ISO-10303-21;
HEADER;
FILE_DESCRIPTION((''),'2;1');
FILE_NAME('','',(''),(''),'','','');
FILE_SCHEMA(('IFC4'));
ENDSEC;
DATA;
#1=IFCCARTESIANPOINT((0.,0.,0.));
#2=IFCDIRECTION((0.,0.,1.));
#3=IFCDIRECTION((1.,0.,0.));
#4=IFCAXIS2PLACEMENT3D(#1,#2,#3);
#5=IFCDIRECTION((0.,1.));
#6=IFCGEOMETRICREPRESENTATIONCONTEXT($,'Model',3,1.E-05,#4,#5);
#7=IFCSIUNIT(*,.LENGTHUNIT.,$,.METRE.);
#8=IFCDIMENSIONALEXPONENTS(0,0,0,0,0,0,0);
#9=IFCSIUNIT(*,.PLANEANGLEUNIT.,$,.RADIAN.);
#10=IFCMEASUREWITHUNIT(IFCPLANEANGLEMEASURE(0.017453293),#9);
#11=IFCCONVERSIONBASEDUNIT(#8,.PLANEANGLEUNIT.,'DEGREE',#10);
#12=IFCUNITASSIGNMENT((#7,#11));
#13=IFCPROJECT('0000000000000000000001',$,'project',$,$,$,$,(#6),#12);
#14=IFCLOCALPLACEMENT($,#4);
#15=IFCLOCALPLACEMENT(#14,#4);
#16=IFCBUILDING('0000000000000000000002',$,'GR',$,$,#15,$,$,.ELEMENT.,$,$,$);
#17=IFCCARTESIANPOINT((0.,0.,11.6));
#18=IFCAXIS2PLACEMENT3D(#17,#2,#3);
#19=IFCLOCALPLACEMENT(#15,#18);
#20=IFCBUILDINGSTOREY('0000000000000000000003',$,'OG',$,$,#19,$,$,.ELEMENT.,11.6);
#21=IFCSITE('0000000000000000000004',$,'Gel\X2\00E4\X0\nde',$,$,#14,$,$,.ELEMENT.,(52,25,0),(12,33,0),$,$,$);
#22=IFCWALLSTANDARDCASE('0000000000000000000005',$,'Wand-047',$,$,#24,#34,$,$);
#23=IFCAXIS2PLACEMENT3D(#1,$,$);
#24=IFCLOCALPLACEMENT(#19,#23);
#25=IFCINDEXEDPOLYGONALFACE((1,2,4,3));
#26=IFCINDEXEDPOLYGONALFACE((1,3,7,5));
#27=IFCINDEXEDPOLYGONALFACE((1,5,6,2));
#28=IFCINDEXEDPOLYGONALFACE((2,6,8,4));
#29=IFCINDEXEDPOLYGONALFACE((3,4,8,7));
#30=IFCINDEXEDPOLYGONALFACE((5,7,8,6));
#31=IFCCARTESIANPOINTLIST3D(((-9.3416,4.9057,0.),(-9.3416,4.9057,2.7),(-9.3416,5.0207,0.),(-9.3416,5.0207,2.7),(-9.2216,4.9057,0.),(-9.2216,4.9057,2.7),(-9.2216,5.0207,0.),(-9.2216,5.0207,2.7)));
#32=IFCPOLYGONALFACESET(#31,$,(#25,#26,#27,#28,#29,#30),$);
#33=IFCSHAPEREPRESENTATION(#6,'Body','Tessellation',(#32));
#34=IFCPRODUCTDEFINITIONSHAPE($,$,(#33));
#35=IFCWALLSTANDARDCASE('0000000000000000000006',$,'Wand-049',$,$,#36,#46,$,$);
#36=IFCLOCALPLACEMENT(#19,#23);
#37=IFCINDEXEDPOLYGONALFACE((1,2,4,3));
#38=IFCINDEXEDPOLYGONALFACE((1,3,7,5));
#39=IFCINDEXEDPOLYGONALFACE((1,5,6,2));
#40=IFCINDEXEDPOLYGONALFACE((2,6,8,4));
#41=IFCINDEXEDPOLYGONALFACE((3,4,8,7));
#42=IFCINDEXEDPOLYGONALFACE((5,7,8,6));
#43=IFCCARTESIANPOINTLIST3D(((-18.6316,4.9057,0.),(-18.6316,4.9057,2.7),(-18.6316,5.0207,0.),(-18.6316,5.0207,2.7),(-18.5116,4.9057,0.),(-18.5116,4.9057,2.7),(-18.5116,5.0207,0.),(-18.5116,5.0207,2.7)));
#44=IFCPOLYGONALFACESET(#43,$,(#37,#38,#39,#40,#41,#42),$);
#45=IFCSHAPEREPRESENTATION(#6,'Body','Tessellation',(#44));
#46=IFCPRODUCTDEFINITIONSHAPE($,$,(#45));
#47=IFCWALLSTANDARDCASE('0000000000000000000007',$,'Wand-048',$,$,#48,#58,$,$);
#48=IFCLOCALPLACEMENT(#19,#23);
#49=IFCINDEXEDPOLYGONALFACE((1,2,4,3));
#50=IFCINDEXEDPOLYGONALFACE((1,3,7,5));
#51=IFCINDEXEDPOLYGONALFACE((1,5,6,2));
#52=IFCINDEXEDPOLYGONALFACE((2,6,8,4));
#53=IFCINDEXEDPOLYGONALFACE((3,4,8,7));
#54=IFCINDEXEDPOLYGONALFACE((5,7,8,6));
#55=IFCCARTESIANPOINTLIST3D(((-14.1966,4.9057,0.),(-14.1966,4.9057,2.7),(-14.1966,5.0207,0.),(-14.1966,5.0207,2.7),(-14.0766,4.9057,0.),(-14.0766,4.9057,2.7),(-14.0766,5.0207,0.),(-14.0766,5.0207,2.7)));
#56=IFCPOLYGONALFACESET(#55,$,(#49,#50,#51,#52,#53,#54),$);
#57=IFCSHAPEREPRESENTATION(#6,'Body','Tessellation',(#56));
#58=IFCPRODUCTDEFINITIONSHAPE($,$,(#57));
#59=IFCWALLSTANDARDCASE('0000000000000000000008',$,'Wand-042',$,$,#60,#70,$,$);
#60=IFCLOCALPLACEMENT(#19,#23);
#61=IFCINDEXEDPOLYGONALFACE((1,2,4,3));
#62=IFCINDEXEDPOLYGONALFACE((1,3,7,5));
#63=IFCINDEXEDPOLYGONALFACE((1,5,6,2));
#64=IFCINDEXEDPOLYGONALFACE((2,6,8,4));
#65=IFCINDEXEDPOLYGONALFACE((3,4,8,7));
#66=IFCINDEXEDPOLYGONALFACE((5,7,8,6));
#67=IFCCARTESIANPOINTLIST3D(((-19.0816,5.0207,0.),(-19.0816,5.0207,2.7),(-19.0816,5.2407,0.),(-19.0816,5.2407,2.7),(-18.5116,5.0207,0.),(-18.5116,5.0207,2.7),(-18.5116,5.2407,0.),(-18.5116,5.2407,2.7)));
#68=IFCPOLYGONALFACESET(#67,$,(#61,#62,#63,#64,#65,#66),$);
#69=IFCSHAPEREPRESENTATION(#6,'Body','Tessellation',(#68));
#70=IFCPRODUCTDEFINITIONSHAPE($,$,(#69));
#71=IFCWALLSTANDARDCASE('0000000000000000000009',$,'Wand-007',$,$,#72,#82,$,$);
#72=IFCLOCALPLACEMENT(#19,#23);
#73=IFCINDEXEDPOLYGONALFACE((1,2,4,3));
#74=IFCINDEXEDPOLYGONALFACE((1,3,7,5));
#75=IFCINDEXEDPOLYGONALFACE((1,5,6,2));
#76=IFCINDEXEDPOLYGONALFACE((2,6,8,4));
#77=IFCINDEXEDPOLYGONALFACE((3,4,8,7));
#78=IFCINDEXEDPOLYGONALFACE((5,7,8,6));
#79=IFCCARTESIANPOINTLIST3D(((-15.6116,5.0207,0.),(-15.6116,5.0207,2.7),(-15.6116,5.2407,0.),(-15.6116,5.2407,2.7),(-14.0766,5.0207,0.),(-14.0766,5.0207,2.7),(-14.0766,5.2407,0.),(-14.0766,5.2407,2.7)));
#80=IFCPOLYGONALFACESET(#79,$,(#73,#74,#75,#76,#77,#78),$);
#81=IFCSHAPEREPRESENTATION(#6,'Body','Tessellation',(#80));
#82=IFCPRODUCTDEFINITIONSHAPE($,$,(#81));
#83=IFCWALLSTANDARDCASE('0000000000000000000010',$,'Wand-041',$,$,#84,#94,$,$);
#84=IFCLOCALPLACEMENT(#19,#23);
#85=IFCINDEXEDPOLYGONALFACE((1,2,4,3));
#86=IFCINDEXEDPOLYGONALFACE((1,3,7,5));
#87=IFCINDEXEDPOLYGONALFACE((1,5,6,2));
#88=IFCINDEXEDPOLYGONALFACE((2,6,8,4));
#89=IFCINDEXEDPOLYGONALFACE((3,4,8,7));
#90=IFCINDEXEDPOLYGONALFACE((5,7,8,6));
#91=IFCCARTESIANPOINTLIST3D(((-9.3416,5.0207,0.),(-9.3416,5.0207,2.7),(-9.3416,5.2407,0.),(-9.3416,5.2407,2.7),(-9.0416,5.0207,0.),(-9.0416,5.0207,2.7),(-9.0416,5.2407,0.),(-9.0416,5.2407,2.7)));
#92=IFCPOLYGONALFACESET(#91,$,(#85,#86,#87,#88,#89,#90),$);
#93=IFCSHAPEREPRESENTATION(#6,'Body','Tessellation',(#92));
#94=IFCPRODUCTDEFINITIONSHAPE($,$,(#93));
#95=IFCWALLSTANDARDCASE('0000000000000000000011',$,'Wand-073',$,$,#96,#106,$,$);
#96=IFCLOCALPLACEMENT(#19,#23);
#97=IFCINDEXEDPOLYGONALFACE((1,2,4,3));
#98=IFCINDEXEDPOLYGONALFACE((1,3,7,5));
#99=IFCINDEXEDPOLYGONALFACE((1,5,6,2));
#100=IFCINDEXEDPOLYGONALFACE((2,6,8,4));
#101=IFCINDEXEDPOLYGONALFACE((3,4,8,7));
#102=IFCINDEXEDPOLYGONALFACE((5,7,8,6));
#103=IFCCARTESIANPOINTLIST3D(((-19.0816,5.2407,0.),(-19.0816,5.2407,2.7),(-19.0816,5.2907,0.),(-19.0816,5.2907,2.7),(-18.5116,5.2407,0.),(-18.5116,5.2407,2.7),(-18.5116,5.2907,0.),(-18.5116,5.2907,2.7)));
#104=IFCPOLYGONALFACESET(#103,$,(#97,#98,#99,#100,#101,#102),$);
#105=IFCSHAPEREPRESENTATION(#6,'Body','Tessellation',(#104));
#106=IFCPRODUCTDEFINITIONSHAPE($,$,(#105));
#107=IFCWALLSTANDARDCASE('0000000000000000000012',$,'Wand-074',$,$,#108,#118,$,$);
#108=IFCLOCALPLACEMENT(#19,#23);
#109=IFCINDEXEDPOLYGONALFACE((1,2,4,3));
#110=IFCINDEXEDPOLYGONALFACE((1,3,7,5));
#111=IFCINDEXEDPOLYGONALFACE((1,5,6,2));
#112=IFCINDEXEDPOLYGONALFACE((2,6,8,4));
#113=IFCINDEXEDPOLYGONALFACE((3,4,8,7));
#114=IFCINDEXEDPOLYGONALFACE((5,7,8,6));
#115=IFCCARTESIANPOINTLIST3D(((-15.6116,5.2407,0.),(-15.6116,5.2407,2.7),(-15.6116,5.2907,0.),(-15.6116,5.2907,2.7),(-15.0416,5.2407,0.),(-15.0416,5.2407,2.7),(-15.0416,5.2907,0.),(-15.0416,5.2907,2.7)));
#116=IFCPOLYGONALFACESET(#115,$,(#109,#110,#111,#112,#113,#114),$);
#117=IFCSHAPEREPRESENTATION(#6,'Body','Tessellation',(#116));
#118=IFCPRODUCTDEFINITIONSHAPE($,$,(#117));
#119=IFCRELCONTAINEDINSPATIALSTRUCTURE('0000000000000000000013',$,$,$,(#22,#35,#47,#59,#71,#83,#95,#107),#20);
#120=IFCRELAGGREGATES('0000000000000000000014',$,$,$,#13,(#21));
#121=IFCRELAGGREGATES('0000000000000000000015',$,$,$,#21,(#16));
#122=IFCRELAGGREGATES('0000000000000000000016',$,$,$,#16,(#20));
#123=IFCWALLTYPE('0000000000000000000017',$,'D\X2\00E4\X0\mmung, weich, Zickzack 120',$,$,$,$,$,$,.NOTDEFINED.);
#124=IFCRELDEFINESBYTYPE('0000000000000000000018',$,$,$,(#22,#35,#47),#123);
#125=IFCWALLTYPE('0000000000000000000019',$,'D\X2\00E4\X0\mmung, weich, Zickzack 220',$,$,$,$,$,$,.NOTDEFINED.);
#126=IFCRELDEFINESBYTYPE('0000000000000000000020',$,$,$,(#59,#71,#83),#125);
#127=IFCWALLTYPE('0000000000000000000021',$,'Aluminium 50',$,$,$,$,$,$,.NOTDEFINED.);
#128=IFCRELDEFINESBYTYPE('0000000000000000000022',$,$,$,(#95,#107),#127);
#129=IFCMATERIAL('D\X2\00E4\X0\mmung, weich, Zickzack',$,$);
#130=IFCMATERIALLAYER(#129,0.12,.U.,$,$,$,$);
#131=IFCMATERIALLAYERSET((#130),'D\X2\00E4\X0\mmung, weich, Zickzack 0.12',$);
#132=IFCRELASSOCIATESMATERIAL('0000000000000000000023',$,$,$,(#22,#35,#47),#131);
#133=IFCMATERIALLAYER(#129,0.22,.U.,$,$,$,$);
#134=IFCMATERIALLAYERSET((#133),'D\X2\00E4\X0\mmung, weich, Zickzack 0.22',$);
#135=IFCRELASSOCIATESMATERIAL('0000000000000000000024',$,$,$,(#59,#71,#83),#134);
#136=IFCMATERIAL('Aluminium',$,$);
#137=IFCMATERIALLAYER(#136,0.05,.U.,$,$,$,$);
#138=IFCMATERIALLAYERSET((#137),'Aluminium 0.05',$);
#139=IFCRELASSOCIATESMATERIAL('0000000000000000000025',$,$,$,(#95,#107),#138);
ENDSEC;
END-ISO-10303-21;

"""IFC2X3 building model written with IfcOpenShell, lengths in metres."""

from ifc_helpers import new_model, entity, si_unit, converted_unit, direction, frame, origin_with_axes, place, context, project, spatial, polyline, outline, extrude, material, layer, layer_set, layer_usage, type_object, element, save


model = new_model("IFC2X3")

# Units and contexts
model_context = context("Model", 3, precision=1e-05, world=origin_with_axes(), true_north=direction((0.0, 1.0)))
ifc_project = project(units=[si_unit("LENGTHUNIT", "METRE"), converted_unit("PLANEANGLEUNIT", "DEGREE", entity("IfcPlaneAngleMeasure", 0.017453293), si_unit("PLANEANGLEUNIT", "RADIAN"), dimensions=[0, 0, 0, 0, 0, 0, 0])], contexts=[model_context])

# Site, building, storey
site_placement = place(None, origin_with_axes())
site = spatial("IfcSite", under=ifc_project, at=site_placement, Name="Gelände", CompositionType="ELEMENT", RefLatitude=(52, 25, 0), RefLongitude=(12, 33, 0))
building_placement = place(site_placement, origin_with_axes())
building = spatial("IfcBuilding", under=site, at=building_placement, Name="GR", CompositionType="ELEMENT")
storey_placement = place(building_placement, frame((0.0, 0.0, 11.6), z_axis=(0.0, 0.0, 1.0), x_axis=(1.0, 0.0, 0.0)))
storey = spatial("IfcBuildingStorey", under=building, at=storey_placement, Name="OG", CompositionType="ELEMENT", Elevation=11.6)

# Shared definitions
ifc_material_1 = material(Name="Dämmung, weich, Zickzack")

# Walls
ifc_layer_1 = layer(ifc_material_1, 0.12, ventilated="UNKNOWN")
ifc_layer_set_1 = layer_set([ifc_layer_1], Name="Dämmung, weich, Zickzack 0.12")
wall_type_1 = type_object("IfcWallType", Name="Dämmung, weich, Zickzack 120", PredefinedType="NOTDEFINED")
ifc_layer_usage_1 = layer_usage(ifc_layer_set_1, "AXIS2", "POSITIVE", 0.0)
wall_1_placement = place(storey_placement, frame((-9.3416, 5.0207, 0.0), z_axis=(0.0, 0.0, 1.0), x_axis=(0.0, -1.0, 0.0)))
element("IfcWallStandardCase", 1, at=wall_1_placement, inside=storey, type_object=wall_type_1, material=ifc_layer_usage_1, Name="Wand-047", context=model_context, shape_type="SweptSolid", body=[
    extrude(outline(polyline([(0.0, 0.0), (0.115, 0.0), (0.115, 0.12), (0.0, 0.12), (0.0, 0.0)])), origin_with_axes(), (0.0, 0.0, 1.0), 2.7),
])
ifc_layer_usage_2 = layer_usage(ifc_layer_set_1, "AXIS2", "POSITIVE", 0.0)
wall_2_placement = place(storey_placement, frame((-18.5116, 4.9057, 0.0), z_axis=(0.0, 0.0, 1.0), x_axis=(0.0, 1.0, 0.0)))
element("IfcWallStandardCase", 2, at=wall_2_placement, inside=storey, type_object=wall_type_1, material=ifc_layer_usage_2, Name="Wand-049", context=model_context, shape_type="SweptSolid", body=[
    extrude(outline(polyline([(0.0, 0.0), (0.115, 0.0), (0.115, 0.12), (0.0, 0.12), (0.0, 0.0)])), origin_with_axes(), (0.0, 0.0, 1.0), 2.7),
])
ifc_layer_usage_3 = layer_usage(ifc_layer_set_1, "AXIS2", "POSITIVE", 0.0)
wall_3_placement = place(storey_placement, frame((-14.0766, 4.9057, 0.0), z_axis=(0.0, 0.0, 1.0), x_axis=(0.0, 1.0, 0.0)))
element("IfcWallStandardCase", 3, at=wall_3_placement, inside=storey, type_object=wall_type_1, material=ifc_layer_usage_3, Name="Wand-048", context=model_context, shape_type="SweptSolid", body=[
    extrude(outline(polyline([(0.0, 0.0), (0.115, 0.0), (0.115, 0.12), (0.0, 0.12), (0.0, 0.0)])), origin_with_axes(), (0.0, 0.0, 1.0), 2.7),
])
ifc_layer_2 = layer(ifc_material_1, 0.22, ventilated="UNKNOWN")
ifc_layer_set_2 = layer_set([ifc_layer_2], Name="Dämmung, weich, Zickzack 0.22")
ifc_layer_usage_4 = layer_usage(ifc_layer_set_2, "AXIS2", "POSITIVE", 0.0)
wall_type_2 = type_object("IfcWallType", Name="Dämmung, weich, Zickzack 220", PredefinedType="NOTDEFINED")
wall_4_placement = place(storey_placement, frame((-19.0816, 5.0207, 0.0), z_axis=(0.0, 0.0, 1.0), x_axis=(1.0, 0.0, 0.0)))
element("IfcWallStandardCase", 4, at=wall_4_placement, inside=storey, type_object=wall_type_2, material=ifc_layer_usage_4, Name="Wand-042", context=model_context, shape_type="SweptSolid", body=[
    extrude(outline(polyline([(0.0, 0.0), (0.57, 0.0), (0.57, 0.22), (0.0, 0.22), (0.0, 0.0)])), origin_with_axes(), (0.0, 0.0, 1.0), 2.7),
])
ifc_layer_usage_5 = layer_usage(ifc_layer_set_2, "AXIS2", "POSITIVE", 0.0)
wall_5_placement = place(storey_placement, frame((-15.6116, 5.0207, 0.0), z_axis=(0.0, 0.0, 1.0), x_axis=(1.0, 0.0, 0.0)))
element("IfcWallStandardCase", 5, at=wall_5_placement, inside=storey, type_object=wall_type_2, material=ifc_layer_usage_5, Name="Wand-007", context=model_context, shape_type="SweptSolid", body=[
    extrude(outline(polyline([(0.0, 0.0), (1.535, 0.0), (1.535, 0.22), (0.0, 0.22), (0.0, 0.0)])), origin_with_axes(), (0.0, 0.0, 1.0), 2.7),
])
ifc_layer_usage_6 = layer_usage(ifc_layer_set_2, "AXIS2", "POSITIVE", 0.0)
wall_6_placement = place(storey_placement, frame((-9.3416, 5.0207, 0.0), z_axis=(0.0, 0.0, 1.0), x_axis=(1.0, 0.0, 0.0)))
element("IfcWallStandardCase", 6, at=wall_6_placement, inside=storey, type_object=wall_type_2, material=ifc_layer_usage_6, Name="Wand-041", context=model_context, shape_type="SweptSolid", body=[
    extrude(outline(polyline([(0.0, 0.0), (0.3, 0.0), (0.3, 0.22), (0.0, 0.22), (0.0, 0.0)])), origin_with_axes(), (0.0, 0.0, 1.0), 2.7),
])
ifc_material_2 = material(Name="Aluminium")
ifc_layer_3 = layer(ifc_material_2, 0.05, ventilated="UNKNOWN")
ifc_layer_set_3 = layer_set([ifc_layer_3], Name="Aluminium 0.05")
ifc_layer_usage_7 = layer_usage(ifc_layer_set_3, "AXIS2", "POSITIVE", 0.0)
wall_type_3 = type_object("IfcWallType", Name="Aluminium 50", PredefinedType="NOTDEFINED")
wall_7_placement = place(storey_placement, frame((-19.0816, 5.2407, 0.0), z_axis=(0.0, 0.0, 1.0), x_axis=(1.0, 0.0, 0.0)))
element("IfcWallStandardCase", 7, at=wall_7_placement, inside=storey, type_object=wall_type_3, material=ifc_layer_usage_7, Name="Wand-073", context=model_context, shape_type="SweptSolid", body=[
    extrude(outline(polyline([(0.0, 0.0), (0.57, 0.0), (0.57, 0.05), (0.0, 0.05), (0.0, 0.0)])), origin_with_axes(), (0.0, 0.0, 1.0), 2.7),
])
ifc_layer_usage_8 = layer_usage(ifc_layer_set_3, "AXIS2", "POSITIVE", 0.0)
wall_8_placement = place(storey_placement, frame((-15.6116, 5.2407, 0.0), z_axis=(0.0, 0.0, 1.0), x_axis=(1.0, 0.0, 0.0)))
element("IfcWallStandardCase", 8, at=wall_8_placement, inside=storey, type_object=wall_type_3, material=ifc_layer_usage_8, Name="Wand-074", context=model_context, shape_type="SweptSolid", body=[
    extrude(outline(polyline([(0.0, 0.0), (0.57, 0.0), (0.57, 0.05), (0.0, 0.05), (0.0, 0.0)])), origin_with_axes(), (0.0, 0.0, 1.0), 2.7),
])

save(model, "model.ifc")
